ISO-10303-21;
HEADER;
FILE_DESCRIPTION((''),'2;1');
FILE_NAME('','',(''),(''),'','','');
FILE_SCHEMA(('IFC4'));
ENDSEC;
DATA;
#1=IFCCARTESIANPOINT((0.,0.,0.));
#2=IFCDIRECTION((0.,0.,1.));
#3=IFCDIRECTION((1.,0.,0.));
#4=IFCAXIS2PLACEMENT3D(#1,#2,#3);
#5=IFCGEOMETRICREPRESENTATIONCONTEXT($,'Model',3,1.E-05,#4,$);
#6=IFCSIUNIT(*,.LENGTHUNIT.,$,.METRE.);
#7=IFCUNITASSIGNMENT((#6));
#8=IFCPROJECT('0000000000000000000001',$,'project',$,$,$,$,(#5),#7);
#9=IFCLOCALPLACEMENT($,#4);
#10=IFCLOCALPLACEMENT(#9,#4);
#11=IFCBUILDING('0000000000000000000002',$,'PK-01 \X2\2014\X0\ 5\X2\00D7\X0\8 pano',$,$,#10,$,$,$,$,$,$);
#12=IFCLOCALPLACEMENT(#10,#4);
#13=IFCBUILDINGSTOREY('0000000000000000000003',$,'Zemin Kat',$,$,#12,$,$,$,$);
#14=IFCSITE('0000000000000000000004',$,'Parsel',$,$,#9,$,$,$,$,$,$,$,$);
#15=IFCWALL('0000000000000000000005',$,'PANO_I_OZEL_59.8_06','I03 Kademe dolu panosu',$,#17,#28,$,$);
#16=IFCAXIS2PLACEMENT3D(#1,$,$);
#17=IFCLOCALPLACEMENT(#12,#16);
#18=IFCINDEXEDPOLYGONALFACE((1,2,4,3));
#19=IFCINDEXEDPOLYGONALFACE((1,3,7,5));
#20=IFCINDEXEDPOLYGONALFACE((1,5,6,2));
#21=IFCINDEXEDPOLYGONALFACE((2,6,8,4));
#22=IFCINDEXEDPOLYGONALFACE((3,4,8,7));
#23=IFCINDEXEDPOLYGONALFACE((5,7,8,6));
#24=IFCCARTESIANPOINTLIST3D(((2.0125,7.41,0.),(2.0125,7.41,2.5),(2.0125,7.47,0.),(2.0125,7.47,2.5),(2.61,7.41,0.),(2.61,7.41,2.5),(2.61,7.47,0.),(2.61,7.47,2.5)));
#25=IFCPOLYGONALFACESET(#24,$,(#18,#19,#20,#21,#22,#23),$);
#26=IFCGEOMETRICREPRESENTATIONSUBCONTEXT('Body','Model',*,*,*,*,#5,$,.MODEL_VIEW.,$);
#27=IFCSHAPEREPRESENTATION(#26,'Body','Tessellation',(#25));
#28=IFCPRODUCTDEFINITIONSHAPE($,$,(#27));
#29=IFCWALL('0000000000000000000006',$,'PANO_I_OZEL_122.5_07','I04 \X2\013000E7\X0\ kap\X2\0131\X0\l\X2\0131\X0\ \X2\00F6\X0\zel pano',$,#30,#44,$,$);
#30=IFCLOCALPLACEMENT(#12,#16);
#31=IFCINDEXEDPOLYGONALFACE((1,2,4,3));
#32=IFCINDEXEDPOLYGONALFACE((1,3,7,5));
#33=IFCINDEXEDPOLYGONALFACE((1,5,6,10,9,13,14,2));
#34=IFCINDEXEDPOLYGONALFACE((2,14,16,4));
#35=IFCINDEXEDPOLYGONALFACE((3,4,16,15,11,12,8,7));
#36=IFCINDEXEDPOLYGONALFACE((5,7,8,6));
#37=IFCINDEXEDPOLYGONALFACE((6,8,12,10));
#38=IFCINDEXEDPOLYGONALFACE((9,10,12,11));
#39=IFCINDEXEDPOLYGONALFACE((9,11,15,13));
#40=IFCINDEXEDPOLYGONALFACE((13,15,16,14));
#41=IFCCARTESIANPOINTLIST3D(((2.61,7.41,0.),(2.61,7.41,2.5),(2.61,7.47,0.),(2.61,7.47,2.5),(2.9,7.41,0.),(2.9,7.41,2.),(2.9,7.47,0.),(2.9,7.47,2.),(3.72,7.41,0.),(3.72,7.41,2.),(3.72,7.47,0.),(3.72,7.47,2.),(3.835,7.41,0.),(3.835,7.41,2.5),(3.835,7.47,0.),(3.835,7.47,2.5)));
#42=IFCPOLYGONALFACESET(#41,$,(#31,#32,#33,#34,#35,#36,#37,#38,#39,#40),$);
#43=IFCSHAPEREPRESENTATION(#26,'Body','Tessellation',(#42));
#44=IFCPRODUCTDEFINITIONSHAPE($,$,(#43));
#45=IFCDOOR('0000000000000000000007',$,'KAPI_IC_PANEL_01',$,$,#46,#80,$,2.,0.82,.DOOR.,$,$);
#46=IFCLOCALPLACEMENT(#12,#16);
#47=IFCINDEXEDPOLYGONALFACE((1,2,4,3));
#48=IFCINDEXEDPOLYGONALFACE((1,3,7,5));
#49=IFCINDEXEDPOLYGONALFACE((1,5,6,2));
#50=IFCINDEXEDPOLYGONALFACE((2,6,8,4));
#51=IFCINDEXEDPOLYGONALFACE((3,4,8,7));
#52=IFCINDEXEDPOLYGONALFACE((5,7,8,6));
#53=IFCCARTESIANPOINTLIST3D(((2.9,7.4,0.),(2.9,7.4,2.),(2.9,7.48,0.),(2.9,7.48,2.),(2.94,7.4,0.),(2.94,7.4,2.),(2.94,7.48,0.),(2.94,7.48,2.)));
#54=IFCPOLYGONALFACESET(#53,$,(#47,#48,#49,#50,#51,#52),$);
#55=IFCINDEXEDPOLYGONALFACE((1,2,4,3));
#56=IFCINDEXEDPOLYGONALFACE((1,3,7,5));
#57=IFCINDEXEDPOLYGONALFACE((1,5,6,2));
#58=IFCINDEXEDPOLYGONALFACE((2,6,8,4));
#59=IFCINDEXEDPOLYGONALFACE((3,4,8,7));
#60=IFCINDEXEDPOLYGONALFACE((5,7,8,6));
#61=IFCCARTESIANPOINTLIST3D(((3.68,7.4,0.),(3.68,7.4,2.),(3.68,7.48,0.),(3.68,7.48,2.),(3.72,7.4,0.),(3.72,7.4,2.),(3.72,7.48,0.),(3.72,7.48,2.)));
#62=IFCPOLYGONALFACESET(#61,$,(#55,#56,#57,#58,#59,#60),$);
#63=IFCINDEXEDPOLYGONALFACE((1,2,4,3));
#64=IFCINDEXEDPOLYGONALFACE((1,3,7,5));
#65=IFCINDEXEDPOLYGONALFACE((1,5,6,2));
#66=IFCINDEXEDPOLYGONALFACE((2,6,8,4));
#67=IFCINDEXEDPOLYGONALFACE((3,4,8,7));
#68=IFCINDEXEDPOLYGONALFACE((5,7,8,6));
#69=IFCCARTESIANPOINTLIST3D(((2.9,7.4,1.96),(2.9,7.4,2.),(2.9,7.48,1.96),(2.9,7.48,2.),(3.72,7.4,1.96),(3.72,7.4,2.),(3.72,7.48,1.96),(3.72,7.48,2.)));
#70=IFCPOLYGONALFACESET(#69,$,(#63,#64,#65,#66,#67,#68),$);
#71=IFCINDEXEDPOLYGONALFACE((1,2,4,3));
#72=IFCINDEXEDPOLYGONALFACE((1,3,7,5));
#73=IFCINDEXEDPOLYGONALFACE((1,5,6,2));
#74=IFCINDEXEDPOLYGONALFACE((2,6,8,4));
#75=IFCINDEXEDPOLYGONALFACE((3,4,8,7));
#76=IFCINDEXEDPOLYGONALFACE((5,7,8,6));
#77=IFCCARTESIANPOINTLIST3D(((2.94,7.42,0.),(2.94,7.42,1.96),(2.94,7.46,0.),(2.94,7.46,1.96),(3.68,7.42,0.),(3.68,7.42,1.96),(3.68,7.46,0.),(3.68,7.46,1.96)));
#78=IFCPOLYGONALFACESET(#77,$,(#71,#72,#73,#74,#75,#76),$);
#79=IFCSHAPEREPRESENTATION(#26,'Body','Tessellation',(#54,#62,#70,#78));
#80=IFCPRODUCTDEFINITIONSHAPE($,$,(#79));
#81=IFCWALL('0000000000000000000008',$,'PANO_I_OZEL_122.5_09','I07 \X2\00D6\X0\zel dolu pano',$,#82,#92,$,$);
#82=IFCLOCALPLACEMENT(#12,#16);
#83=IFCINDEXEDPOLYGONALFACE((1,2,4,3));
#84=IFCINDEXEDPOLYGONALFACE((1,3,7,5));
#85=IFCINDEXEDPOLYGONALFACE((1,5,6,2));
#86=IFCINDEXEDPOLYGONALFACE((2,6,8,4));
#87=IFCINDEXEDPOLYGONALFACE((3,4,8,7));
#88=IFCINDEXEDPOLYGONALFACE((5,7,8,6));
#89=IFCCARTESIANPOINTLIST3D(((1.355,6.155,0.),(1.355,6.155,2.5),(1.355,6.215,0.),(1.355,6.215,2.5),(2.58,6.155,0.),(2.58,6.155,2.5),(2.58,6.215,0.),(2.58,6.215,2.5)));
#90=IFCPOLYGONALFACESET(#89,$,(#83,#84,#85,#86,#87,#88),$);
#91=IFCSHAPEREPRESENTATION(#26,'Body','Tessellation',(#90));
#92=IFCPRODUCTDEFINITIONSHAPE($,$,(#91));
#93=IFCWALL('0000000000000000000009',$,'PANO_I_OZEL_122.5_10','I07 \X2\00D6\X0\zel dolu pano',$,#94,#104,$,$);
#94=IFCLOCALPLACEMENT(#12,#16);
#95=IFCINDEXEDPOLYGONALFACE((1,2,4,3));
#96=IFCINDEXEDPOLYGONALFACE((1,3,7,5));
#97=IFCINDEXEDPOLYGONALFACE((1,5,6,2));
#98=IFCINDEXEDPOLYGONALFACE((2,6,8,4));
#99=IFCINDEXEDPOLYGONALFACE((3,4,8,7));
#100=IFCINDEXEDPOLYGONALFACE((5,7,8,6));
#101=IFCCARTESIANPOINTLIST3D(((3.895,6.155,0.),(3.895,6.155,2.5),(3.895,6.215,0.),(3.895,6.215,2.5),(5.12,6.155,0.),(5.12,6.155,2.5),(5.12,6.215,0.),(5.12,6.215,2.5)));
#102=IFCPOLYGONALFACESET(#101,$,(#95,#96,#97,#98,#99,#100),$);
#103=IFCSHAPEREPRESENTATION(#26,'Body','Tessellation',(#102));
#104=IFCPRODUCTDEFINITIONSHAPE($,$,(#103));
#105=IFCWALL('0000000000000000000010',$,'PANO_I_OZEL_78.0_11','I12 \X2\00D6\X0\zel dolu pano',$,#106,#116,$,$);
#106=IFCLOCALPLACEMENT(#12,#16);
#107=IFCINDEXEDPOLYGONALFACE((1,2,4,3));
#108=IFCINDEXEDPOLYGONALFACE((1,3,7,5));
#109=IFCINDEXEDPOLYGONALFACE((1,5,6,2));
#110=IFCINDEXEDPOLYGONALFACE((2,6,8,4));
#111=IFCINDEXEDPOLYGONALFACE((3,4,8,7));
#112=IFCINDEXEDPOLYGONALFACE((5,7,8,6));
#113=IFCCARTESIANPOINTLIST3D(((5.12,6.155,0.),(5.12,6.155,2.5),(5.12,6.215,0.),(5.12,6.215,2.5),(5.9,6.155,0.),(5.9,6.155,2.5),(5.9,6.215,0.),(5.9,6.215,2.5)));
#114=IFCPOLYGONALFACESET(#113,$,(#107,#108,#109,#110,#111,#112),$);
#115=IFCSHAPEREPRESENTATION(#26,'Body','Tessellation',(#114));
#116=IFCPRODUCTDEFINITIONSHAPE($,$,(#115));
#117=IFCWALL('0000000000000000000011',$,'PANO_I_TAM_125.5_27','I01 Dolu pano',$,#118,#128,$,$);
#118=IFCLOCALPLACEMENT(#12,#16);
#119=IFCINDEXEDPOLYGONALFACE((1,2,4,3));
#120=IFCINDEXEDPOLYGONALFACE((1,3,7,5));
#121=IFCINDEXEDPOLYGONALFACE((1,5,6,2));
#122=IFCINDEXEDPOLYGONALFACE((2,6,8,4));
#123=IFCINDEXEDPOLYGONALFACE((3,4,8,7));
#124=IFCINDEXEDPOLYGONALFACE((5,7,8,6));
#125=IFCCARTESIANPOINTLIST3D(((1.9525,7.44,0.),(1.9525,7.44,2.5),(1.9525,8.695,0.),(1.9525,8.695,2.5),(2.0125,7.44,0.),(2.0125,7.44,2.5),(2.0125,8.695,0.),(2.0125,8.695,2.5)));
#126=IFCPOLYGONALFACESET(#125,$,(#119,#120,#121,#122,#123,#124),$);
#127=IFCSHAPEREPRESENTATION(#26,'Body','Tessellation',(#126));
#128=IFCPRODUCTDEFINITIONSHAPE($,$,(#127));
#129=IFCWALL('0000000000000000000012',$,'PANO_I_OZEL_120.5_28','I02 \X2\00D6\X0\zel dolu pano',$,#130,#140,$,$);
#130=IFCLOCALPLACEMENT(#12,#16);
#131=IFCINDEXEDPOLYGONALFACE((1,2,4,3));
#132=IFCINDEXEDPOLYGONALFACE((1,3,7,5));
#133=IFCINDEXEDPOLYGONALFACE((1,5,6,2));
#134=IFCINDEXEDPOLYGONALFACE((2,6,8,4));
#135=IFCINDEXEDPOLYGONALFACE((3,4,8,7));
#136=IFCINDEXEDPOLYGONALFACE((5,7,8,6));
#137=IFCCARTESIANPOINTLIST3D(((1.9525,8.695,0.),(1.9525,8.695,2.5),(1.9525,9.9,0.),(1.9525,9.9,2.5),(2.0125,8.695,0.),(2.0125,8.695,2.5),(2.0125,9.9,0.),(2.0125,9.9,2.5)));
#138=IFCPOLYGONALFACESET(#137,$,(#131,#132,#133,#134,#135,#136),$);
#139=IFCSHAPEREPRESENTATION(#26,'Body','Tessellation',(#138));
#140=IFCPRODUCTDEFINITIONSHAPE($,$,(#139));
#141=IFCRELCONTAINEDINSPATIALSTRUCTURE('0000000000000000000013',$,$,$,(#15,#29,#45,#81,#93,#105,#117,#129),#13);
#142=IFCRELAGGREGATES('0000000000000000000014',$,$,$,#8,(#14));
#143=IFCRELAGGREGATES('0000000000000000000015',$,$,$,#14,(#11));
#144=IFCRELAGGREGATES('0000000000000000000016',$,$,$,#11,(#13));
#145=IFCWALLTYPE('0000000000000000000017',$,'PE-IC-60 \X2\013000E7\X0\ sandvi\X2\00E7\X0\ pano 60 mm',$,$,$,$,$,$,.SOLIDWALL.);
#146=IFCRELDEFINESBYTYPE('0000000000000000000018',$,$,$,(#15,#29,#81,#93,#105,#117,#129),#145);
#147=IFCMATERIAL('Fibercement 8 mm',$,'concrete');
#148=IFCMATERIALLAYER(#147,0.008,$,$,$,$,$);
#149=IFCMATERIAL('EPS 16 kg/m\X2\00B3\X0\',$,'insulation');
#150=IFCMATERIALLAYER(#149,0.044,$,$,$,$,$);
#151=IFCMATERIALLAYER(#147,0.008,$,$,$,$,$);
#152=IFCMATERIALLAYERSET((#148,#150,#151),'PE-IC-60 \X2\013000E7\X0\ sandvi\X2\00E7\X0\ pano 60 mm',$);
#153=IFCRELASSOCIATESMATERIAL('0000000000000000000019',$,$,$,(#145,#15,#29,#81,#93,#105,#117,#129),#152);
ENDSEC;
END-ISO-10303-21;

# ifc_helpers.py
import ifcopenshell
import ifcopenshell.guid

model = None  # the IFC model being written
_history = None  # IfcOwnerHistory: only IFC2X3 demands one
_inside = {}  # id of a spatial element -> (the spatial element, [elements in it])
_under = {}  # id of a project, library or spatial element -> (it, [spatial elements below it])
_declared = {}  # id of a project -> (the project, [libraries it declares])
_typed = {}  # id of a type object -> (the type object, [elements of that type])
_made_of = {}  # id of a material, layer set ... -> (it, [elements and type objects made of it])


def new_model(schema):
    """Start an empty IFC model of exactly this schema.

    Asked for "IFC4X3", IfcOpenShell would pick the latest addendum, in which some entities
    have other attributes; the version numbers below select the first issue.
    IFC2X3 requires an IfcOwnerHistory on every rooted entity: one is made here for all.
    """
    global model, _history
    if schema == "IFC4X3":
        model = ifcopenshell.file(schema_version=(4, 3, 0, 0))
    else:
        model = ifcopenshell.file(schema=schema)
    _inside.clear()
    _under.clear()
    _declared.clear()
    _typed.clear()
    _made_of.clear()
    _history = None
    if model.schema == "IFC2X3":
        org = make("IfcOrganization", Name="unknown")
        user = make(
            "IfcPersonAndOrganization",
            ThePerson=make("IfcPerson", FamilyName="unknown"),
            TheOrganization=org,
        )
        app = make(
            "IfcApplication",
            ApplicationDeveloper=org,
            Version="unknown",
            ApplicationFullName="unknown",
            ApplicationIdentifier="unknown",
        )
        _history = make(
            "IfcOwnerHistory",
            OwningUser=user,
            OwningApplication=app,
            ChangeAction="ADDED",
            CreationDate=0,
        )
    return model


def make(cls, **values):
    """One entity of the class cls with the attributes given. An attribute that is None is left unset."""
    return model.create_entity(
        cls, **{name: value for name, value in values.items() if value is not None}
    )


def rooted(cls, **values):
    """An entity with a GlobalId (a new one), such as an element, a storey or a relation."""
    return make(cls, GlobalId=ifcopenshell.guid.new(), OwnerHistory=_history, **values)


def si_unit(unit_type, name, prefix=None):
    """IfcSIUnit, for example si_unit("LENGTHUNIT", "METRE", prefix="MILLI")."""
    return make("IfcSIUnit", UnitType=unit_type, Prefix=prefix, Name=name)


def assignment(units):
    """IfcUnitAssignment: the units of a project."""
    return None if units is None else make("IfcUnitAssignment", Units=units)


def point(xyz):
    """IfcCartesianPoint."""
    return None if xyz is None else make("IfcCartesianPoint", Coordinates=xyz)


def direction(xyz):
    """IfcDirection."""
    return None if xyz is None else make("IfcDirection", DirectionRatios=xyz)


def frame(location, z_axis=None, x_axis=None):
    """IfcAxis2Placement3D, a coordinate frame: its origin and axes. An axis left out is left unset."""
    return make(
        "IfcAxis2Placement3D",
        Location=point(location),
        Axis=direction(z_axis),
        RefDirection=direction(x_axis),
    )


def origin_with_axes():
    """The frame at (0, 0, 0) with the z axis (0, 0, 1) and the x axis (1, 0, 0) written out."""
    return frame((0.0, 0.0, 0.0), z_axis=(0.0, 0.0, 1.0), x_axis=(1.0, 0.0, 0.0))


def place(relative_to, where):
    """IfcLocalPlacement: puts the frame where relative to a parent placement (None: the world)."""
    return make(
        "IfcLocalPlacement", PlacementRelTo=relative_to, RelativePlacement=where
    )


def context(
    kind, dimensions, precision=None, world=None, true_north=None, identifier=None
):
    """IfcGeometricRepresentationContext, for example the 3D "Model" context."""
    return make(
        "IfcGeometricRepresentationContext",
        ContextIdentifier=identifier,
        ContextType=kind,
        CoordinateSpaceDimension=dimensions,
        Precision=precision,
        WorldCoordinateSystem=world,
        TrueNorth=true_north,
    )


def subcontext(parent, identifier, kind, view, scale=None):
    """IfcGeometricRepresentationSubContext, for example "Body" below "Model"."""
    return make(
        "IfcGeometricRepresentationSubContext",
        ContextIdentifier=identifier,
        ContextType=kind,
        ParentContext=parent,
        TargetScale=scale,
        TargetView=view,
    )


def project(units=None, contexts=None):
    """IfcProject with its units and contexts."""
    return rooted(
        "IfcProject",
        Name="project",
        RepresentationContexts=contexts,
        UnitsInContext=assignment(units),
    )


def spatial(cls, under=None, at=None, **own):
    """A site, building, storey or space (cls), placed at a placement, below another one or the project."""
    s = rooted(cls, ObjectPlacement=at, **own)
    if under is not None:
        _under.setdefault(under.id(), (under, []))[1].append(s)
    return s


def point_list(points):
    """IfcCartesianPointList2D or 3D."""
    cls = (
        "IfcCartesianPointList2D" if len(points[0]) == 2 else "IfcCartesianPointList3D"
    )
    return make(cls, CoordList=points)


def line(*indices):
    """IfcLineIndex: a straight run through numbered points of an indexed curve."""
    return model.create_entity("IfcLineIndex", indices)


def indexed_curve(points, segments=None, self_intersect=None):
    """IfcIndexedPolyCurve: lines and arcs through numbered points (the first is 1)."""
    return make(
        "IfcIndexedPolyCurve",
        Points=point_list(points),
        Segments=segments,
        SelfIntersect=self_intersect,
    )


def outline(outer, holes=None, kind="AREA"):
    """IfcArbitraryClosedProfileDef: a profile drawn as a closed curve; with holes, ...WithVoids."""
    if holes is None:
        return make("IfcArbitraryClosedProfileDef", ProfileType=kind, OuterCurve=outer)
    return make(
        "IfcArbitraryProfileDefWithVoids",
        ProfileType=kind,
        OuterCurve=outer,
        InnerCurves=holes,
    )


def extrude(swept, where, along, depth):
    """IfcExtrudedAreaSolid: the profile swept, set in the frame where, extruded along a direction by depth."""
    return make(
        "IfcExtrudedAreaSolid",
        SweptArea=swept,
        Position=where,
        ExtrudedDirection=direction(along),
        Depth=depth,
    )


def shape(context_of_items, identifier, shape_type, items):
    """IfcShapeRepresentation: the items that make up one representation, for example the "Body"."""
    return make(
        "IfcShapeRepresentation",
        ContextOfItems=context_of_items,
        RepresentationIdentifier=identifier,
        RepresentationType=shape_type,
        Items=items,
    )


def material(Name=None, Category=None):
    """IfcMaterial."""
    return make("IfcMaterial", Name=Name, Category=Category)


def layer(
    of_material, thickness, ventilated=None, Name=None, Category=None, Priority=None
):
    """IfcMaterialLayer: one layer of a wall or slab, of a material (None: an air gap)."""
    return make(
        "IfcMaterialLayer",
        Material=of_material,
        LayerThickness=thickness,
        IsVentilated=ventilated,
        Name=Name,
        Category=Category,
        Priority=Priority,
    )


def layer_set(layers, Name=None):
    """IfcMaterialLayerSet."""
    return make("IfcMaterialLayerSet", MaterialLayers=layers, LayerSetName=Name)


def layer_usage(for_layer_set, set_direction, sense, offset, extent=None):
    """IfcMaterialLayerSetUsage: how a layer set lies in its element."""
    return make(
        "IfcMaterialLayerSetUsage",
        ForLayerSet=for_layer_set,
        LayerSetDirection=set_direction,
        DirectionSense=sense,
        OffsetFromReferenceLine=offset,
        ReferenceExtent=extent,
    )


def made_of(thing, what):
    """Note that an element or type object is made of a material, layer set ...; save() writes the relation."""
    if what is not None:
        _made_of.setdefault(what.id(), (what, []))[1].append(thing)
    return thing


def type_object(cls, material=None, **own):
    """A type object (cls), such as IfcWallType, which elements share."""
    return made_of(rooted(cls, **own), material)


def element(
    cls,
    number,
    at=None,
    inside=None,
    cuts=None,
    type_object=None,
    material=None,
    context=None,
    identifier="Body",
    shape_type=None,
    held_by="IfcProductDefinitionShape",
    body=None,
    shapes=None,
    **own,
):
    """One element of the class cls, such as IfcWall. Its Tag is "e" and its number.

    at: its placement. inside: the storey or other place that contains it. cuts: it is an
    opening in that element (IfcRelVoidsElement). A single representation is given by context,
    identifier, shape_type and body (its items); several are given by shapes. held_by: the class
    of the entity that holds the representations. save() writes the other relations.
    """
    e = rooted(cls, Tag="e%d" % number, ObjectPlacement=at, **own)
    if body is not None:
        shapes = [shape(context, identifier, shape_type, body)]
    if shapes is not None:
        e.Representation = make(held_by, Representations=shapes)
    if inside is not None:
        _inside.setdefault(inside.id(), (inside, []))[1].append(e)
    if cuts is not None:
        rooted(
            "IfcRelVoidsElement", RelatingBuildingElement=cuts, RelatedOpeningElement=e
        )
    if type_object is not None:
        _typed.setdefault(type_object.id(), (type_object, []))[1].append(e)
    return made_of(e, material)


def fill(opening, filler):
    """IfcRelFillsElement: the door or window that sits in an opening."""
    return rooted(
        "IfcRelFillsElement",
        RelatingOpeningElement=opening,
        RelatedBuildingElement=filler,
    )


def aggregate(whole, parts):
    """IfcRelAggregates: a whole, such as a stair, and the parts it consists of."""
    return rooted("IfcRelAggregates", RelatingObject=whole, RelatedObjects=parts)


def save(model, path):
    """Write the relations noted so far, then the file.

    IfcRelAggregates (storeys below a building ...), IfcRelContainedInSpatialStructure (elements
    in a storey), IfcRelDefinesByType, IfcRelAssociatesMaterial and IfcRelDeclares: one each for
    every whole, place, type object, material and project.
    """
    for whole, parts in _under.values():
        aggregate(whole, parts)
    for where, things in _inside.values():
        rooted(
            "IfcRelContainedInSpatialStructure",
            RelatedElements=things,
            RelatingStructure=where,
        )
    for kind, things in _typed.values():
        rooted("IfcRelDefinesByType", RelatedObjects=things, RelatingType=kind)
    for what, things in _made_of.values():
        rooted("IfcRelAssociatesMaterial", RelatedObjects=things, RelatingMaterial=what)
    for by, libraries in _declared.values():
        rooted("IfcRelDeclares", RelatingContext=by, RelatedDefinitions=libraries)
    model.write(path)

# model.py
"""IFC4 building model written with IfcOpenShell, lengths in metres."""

from ifc_helpers import new_model, si_unit, frame, origin_with_axes, place, context, subcontext, project, spatial, line, indexed_curve, outline, extrude, material, layer, layer_set, layer_usage, type_object, element, fill, save


model = new_model("IFC4")

# Units and contexts
model_context = context("Model", 3, precision=1e-05, world=origin_with_axes())
body_context = subcontext(model_context, "Body", "Model", "MODEL_VIEW")
ifc_project = project(units=[si_unit("LENGTHUNIT", "METRE")], contexts=[model_context])

# Site, building, storey
site_placement = place(None, origin_with_axes())
site = spatial("IfcSite", under=ifc_project, at=site_placement, Name="Parsel")
building_placement = place(site_placement, origin_with_axes())
building = spatial("IfcBuilding", under=site, at=building_placement, Name="PK-01 — 5×8 pano")
storey_placement = place(building_placement, origin_with_axes())
storey = spatial("IfcBuildingStorey", under=building, at=storey_placement, Name="Zemin Kat")

# Shared definitions
ifc_material_1 = material(Name="Fibercement 8 mm", Category="concrete")
ifc_material_2 = material(Name="EPS 16 kg/m³", Category="insulation")

# Wall
ifc_layer_1 = layer(ifc_material_1, 0.008)
ifc_layer_2 = layer(ifc_material_2, 0.044)
ifc_layer_3 = layer(ifc_material_1, 0.008)
ifc_layer_set_1 = layer_set([ifc_layer_1, ifc_layer_2, ifc_layer_3], Name="PE-IC-60 İç sandviç pano 60 mm")
ifc_layer_usage_1 = layer_usage(ifc_layer_set_1, "AXIS2", "POSITIVE", 0.0)
wall_type_1 = type_object("IfcWallType", Name="PE-IC-60 İç sandviç pano 60 mm", PredefinedType="SOLIDWALL", material=ifc_layer_set_1)
wall_1_placement = place(storey_placement, frame((2.0125, 7.41, 0.0), z_axis=(0.0, 0.0, 1.0), x_axis=(1.0, 0.0, 0.0)))
element("IfcWall", 1, at=wall_1_placement, inside=storey, type_object=wall_type_1, material=ifc_layer_usage_1, Name="PANO_I_OZEL_59.8_06", Description="I03 Kademe dolu panosu", context=body_context, shape_type="SweptSolid", body=[
    extrude(outline(indexed_curve([(0.0, 0.0), (0.5975, 0.0), (0.5975, 0.06), (0.0, 0.06)], segments=[line(1, 2, 3, 4, 1)])), origin_with_axes(), (0.0, 0.0, 1.0), 2.5),
])

# Wall, opening, door
ifc_layer_usage_2 = layer_usage(ifc_layer_set_1, "AXIS2", "POSITIVE", 0.0)
wall_2_placement = place(storey_placement, frame((2.61, 7.41, 0.0), z_axis=(0.0, 0.0, 1.0), x_axis=(1.0, 0.0, 0.0)))
wall_2 = element("IfcWall", 2, at=wall_2_placement, inside=storey, type_object=wall_type_1, material=ifc_layer_usage_2, Name="PANO_I_OZEL_122.5_07", Description="I04 İç kapılı özel pano", context=body_context, shape_type="SweptSolid", body=[
    extrude(outline(indexed_curve([(0.0, 0.0), (1.225, 0.0), (1.225, 0.06), (0.0, 0.06)], segments=[line(1, 2, 3, 4, 1)])), origin_with_axes(), (0.0, 0.0, 1.0), 2.5),
])
opening_1_placement = place(wall_2_placement, origin_with_axes())
opening_1 = element("IfcOpeningElement", 3, at=opening_1_placement, cuts=wall_2, PredefinedType="OPENING", context=body_context, shape_type="SweptSolid", body=[
    extrude(outline(indexed_curve([(0.0, 0.0), (0.82, 0.0), (0.82, 0.1), (0.0, 0.1)], segments=[line(1, 2, 3, 4, 1)])), frame((0.29, -0.02, 0.0), z_axis=(0.0, 0.0, 1.0), x_axis=(1.0, 0.0, 0.0)), (0.0, 0.0, 1.0), 2.0),
])
door_1_placement = place(storey_placement, frame((2.61, 7.41, 0.0), z_axis=(0.0, 0.0, 1.0), x_axis=(1.0, 0.0, 0.0)))
door_1 = element("IfcDoor", 4, at=door_1_placement, inside=storey, Name="KAPI_IC_PANEL_01", OverallHeight=2.0, OverallWidth=0.82, PredefinedType="DOOR", context=body_context, shape_type="SweptSolid", body=[
    extrude(outline(indexed_curve([(0.0, 0.0), (0.04, 0.0), (0.04, 0.08), (0.0, 0.08)], segments=[line(1, 2, 3, 4, 1)])), frame((0.29, -0.01, 0.0), z_axis=(0.0, 0.0, 1.0), x_axis=(1.0, 0.0, 0.0)), (0.0, 0.0, 1.0), 2.0),
    extrude(outline(indexed_curve([(0.0, 0.0), (0.04, 0.0), (0.04, 0.08), (0.0, 0.08)], segments=[line(1, 2, 3, 4, 1)])), frame((1.07, -0.01, 0.0), z_axis=(0.0, 0.0, 1.0), x_axis=(1.0, 0.0, 0.0)), (0.0, 0.0, 1.0), 2.0),
    extrude(outline(indexed_curve([(0.0, 0.0), (0.82, 0.0), (0.82, 0.08), (0.0, 0.08)], segments=[line(1, 2, 3, 4, 1)])), frame((0.29, -0.01, 1.96), z_axis=(0.0, 0.0, 1.0), x_axis=(1.0, 0.0, 0.0)), (0.0, 0.0, 1.0), 0.04),
    extrude(outline(indexed_curve([(0.0, 0.0), (0.74, 0.0), (0.74, 0.04), (0.0, 0.04)], segments=[line(1, 2, 3, 4, 1)])), frame((0.33, 0.01, 0.0), z_axis=(0.0, 0.0, 1.0), x_axis=(1.0, 0.0, 0.0)), (0.0, 0.0, 1.0), 1.96),
])
fill(opening_1, door_1)

# Walls
ifc_layer_usage_3 = layer_usage(ifc_layer_set_1, "AXIS2", "POSITIVE", 0.0)
wall_3_placement = place(storey_placement, frame((1.355, 6.155, 0.0), z_axis=(0.0, 0.0, 1.0), x_axis=(1.0, 0.0, 0.0)))
element("IfcWall", 5, at=wall_3_placement, inside=storey, type_object=wall_type_1, material=ifc_layer_usage_3, Name="PANO_I_OZEL_122.5_09", Description="I07 Özel dolu pano", context=body_context, shape_type="SweptSolid", body=[
    extrude(outline(indexed_curve([(0.0, 0.0), (1.225, 0.0), (1.225, 0.06), (0.0, 0.06)], segments=[line(1, 2, 3, 4, 1)])), origin_with_axes(), (0.0, 0.0, 1.0), 2.5),
])
ifc_layer_usage_4 = layer_usage(ifc_layer_set_1, "AXIS2", "POSITIVE", 0.0)
wall_4_placement = place(storey_placement, frame((3.895, 6.155, 0.0), z_axis=(0.0, 0.0, 1.0), x_axis=(1.0, 0.0, 0.0)))
element("IfcWall", 6, at=wall_4_placement, inside=storey, type_object=wall_type_1, material=ifc_layer_usage_4, Name="PANO_I_OZEL_122.5_10", Description="I07 Özel dolu pano", context=body_context, shape_type="SweptSolid", body=[
    extrude(outline(indexed_curve([(0.0, 0.0), (1.225, 0.0), (1.225, 0.06), (0.0, 0.06)], segments=[line(1, 2, 3, 4, 1)])), origin_with_axes(), (0.0, 0.0, 1.0), 2.5),
])
ifc_layer_usage_5 = layer_usage(ifc_layer_set_1, "AXIS2", "POSITIVE", 0.0)
wall_5_placement = place(storey_placement, frame((5.12, 6.155, 0.0), z_axis=(0.0, 0.0, 1.0), x_axis=(1.0, 0.0, 0.0)))
element("IfcWall", 7, at=wall_5_placement, inside=storey, type_object=wall_type_1, material=ifc_layer_usage_5, Name="PANO_I_OZEL_78.0_11", Description="I12 Özel dolu pano", context=body_context, shape_type="SweptSolid", body=[
    extrude(outline(indexed_curve([(0.0, 0.0), (0.78, 0.0), (0.78, 0.06), (0.0, 0.06)], segments=[line(1, 2, 3, 4, 1)])), origin_with_axes(), (0.0, 0.0, 1.0), 2.5),
])
ifc_layer_usage_6 = layer_usage(ifc_layer_set_1, "AXIS2", "POSITIVE", 0.0)
wall_6_placement = place(storey_placement, frame((2.0125, 7.44, 0.0), z_axis=(0.0, 0.0, 1.0), x_axis=(0.0, 1.0, 0.0)))
element("IfcWall", 8, at=wall_6_placement, inside=storey, type_object=wall_type_1, material=ifc_layer_usage_6, Name="PANO_I_TAM_125.5_27", Description="I01 Dolu pano", context=body_context, shape_type="SweptSolid", body=[
    extrude(outline(indexed_curve([(0.0, 0.0), (1.255, 0.0), (1.255, 0.06), (0.0, 0.06)], segments=[line(1, 2, 3, 4, 1)])), origin_with_axes(), (0.0, 0.0, 1.0), 2.5),
])
ifc_layer_usage_7 = layer_usage(ifc_layer_set_1, "AXIS2", "POSITIVE", 0.0)
wall_7_placement = place(storey_placement, frame((2.0125, 8.695, 0.0), z_axis=(0.0, 0.0, 1.0), x_axis=(0.0, 1.0, 0.0)))
element("IfcWall", 9, at=wall_7_placement, inside=storey, type_object=wall_type_1, material=ifc_layer_usage_7, Name="PANO_I_OZEL_120.5_28", Description="I02 Özel dolu pano", context=body_context, shape_type="SweptSolid", body=[
    extrude(outline(indexed_curve([(0.0, 0.0), (1.205, 0.0), (1.205, 0.06), (0.0, 0.06)], segments=[line(1, 2, 3, 4, 1)])), origin_with_axes(), (0.0, 0.0, 1.0), 2.5),
])

save(model, "model.ifc")
